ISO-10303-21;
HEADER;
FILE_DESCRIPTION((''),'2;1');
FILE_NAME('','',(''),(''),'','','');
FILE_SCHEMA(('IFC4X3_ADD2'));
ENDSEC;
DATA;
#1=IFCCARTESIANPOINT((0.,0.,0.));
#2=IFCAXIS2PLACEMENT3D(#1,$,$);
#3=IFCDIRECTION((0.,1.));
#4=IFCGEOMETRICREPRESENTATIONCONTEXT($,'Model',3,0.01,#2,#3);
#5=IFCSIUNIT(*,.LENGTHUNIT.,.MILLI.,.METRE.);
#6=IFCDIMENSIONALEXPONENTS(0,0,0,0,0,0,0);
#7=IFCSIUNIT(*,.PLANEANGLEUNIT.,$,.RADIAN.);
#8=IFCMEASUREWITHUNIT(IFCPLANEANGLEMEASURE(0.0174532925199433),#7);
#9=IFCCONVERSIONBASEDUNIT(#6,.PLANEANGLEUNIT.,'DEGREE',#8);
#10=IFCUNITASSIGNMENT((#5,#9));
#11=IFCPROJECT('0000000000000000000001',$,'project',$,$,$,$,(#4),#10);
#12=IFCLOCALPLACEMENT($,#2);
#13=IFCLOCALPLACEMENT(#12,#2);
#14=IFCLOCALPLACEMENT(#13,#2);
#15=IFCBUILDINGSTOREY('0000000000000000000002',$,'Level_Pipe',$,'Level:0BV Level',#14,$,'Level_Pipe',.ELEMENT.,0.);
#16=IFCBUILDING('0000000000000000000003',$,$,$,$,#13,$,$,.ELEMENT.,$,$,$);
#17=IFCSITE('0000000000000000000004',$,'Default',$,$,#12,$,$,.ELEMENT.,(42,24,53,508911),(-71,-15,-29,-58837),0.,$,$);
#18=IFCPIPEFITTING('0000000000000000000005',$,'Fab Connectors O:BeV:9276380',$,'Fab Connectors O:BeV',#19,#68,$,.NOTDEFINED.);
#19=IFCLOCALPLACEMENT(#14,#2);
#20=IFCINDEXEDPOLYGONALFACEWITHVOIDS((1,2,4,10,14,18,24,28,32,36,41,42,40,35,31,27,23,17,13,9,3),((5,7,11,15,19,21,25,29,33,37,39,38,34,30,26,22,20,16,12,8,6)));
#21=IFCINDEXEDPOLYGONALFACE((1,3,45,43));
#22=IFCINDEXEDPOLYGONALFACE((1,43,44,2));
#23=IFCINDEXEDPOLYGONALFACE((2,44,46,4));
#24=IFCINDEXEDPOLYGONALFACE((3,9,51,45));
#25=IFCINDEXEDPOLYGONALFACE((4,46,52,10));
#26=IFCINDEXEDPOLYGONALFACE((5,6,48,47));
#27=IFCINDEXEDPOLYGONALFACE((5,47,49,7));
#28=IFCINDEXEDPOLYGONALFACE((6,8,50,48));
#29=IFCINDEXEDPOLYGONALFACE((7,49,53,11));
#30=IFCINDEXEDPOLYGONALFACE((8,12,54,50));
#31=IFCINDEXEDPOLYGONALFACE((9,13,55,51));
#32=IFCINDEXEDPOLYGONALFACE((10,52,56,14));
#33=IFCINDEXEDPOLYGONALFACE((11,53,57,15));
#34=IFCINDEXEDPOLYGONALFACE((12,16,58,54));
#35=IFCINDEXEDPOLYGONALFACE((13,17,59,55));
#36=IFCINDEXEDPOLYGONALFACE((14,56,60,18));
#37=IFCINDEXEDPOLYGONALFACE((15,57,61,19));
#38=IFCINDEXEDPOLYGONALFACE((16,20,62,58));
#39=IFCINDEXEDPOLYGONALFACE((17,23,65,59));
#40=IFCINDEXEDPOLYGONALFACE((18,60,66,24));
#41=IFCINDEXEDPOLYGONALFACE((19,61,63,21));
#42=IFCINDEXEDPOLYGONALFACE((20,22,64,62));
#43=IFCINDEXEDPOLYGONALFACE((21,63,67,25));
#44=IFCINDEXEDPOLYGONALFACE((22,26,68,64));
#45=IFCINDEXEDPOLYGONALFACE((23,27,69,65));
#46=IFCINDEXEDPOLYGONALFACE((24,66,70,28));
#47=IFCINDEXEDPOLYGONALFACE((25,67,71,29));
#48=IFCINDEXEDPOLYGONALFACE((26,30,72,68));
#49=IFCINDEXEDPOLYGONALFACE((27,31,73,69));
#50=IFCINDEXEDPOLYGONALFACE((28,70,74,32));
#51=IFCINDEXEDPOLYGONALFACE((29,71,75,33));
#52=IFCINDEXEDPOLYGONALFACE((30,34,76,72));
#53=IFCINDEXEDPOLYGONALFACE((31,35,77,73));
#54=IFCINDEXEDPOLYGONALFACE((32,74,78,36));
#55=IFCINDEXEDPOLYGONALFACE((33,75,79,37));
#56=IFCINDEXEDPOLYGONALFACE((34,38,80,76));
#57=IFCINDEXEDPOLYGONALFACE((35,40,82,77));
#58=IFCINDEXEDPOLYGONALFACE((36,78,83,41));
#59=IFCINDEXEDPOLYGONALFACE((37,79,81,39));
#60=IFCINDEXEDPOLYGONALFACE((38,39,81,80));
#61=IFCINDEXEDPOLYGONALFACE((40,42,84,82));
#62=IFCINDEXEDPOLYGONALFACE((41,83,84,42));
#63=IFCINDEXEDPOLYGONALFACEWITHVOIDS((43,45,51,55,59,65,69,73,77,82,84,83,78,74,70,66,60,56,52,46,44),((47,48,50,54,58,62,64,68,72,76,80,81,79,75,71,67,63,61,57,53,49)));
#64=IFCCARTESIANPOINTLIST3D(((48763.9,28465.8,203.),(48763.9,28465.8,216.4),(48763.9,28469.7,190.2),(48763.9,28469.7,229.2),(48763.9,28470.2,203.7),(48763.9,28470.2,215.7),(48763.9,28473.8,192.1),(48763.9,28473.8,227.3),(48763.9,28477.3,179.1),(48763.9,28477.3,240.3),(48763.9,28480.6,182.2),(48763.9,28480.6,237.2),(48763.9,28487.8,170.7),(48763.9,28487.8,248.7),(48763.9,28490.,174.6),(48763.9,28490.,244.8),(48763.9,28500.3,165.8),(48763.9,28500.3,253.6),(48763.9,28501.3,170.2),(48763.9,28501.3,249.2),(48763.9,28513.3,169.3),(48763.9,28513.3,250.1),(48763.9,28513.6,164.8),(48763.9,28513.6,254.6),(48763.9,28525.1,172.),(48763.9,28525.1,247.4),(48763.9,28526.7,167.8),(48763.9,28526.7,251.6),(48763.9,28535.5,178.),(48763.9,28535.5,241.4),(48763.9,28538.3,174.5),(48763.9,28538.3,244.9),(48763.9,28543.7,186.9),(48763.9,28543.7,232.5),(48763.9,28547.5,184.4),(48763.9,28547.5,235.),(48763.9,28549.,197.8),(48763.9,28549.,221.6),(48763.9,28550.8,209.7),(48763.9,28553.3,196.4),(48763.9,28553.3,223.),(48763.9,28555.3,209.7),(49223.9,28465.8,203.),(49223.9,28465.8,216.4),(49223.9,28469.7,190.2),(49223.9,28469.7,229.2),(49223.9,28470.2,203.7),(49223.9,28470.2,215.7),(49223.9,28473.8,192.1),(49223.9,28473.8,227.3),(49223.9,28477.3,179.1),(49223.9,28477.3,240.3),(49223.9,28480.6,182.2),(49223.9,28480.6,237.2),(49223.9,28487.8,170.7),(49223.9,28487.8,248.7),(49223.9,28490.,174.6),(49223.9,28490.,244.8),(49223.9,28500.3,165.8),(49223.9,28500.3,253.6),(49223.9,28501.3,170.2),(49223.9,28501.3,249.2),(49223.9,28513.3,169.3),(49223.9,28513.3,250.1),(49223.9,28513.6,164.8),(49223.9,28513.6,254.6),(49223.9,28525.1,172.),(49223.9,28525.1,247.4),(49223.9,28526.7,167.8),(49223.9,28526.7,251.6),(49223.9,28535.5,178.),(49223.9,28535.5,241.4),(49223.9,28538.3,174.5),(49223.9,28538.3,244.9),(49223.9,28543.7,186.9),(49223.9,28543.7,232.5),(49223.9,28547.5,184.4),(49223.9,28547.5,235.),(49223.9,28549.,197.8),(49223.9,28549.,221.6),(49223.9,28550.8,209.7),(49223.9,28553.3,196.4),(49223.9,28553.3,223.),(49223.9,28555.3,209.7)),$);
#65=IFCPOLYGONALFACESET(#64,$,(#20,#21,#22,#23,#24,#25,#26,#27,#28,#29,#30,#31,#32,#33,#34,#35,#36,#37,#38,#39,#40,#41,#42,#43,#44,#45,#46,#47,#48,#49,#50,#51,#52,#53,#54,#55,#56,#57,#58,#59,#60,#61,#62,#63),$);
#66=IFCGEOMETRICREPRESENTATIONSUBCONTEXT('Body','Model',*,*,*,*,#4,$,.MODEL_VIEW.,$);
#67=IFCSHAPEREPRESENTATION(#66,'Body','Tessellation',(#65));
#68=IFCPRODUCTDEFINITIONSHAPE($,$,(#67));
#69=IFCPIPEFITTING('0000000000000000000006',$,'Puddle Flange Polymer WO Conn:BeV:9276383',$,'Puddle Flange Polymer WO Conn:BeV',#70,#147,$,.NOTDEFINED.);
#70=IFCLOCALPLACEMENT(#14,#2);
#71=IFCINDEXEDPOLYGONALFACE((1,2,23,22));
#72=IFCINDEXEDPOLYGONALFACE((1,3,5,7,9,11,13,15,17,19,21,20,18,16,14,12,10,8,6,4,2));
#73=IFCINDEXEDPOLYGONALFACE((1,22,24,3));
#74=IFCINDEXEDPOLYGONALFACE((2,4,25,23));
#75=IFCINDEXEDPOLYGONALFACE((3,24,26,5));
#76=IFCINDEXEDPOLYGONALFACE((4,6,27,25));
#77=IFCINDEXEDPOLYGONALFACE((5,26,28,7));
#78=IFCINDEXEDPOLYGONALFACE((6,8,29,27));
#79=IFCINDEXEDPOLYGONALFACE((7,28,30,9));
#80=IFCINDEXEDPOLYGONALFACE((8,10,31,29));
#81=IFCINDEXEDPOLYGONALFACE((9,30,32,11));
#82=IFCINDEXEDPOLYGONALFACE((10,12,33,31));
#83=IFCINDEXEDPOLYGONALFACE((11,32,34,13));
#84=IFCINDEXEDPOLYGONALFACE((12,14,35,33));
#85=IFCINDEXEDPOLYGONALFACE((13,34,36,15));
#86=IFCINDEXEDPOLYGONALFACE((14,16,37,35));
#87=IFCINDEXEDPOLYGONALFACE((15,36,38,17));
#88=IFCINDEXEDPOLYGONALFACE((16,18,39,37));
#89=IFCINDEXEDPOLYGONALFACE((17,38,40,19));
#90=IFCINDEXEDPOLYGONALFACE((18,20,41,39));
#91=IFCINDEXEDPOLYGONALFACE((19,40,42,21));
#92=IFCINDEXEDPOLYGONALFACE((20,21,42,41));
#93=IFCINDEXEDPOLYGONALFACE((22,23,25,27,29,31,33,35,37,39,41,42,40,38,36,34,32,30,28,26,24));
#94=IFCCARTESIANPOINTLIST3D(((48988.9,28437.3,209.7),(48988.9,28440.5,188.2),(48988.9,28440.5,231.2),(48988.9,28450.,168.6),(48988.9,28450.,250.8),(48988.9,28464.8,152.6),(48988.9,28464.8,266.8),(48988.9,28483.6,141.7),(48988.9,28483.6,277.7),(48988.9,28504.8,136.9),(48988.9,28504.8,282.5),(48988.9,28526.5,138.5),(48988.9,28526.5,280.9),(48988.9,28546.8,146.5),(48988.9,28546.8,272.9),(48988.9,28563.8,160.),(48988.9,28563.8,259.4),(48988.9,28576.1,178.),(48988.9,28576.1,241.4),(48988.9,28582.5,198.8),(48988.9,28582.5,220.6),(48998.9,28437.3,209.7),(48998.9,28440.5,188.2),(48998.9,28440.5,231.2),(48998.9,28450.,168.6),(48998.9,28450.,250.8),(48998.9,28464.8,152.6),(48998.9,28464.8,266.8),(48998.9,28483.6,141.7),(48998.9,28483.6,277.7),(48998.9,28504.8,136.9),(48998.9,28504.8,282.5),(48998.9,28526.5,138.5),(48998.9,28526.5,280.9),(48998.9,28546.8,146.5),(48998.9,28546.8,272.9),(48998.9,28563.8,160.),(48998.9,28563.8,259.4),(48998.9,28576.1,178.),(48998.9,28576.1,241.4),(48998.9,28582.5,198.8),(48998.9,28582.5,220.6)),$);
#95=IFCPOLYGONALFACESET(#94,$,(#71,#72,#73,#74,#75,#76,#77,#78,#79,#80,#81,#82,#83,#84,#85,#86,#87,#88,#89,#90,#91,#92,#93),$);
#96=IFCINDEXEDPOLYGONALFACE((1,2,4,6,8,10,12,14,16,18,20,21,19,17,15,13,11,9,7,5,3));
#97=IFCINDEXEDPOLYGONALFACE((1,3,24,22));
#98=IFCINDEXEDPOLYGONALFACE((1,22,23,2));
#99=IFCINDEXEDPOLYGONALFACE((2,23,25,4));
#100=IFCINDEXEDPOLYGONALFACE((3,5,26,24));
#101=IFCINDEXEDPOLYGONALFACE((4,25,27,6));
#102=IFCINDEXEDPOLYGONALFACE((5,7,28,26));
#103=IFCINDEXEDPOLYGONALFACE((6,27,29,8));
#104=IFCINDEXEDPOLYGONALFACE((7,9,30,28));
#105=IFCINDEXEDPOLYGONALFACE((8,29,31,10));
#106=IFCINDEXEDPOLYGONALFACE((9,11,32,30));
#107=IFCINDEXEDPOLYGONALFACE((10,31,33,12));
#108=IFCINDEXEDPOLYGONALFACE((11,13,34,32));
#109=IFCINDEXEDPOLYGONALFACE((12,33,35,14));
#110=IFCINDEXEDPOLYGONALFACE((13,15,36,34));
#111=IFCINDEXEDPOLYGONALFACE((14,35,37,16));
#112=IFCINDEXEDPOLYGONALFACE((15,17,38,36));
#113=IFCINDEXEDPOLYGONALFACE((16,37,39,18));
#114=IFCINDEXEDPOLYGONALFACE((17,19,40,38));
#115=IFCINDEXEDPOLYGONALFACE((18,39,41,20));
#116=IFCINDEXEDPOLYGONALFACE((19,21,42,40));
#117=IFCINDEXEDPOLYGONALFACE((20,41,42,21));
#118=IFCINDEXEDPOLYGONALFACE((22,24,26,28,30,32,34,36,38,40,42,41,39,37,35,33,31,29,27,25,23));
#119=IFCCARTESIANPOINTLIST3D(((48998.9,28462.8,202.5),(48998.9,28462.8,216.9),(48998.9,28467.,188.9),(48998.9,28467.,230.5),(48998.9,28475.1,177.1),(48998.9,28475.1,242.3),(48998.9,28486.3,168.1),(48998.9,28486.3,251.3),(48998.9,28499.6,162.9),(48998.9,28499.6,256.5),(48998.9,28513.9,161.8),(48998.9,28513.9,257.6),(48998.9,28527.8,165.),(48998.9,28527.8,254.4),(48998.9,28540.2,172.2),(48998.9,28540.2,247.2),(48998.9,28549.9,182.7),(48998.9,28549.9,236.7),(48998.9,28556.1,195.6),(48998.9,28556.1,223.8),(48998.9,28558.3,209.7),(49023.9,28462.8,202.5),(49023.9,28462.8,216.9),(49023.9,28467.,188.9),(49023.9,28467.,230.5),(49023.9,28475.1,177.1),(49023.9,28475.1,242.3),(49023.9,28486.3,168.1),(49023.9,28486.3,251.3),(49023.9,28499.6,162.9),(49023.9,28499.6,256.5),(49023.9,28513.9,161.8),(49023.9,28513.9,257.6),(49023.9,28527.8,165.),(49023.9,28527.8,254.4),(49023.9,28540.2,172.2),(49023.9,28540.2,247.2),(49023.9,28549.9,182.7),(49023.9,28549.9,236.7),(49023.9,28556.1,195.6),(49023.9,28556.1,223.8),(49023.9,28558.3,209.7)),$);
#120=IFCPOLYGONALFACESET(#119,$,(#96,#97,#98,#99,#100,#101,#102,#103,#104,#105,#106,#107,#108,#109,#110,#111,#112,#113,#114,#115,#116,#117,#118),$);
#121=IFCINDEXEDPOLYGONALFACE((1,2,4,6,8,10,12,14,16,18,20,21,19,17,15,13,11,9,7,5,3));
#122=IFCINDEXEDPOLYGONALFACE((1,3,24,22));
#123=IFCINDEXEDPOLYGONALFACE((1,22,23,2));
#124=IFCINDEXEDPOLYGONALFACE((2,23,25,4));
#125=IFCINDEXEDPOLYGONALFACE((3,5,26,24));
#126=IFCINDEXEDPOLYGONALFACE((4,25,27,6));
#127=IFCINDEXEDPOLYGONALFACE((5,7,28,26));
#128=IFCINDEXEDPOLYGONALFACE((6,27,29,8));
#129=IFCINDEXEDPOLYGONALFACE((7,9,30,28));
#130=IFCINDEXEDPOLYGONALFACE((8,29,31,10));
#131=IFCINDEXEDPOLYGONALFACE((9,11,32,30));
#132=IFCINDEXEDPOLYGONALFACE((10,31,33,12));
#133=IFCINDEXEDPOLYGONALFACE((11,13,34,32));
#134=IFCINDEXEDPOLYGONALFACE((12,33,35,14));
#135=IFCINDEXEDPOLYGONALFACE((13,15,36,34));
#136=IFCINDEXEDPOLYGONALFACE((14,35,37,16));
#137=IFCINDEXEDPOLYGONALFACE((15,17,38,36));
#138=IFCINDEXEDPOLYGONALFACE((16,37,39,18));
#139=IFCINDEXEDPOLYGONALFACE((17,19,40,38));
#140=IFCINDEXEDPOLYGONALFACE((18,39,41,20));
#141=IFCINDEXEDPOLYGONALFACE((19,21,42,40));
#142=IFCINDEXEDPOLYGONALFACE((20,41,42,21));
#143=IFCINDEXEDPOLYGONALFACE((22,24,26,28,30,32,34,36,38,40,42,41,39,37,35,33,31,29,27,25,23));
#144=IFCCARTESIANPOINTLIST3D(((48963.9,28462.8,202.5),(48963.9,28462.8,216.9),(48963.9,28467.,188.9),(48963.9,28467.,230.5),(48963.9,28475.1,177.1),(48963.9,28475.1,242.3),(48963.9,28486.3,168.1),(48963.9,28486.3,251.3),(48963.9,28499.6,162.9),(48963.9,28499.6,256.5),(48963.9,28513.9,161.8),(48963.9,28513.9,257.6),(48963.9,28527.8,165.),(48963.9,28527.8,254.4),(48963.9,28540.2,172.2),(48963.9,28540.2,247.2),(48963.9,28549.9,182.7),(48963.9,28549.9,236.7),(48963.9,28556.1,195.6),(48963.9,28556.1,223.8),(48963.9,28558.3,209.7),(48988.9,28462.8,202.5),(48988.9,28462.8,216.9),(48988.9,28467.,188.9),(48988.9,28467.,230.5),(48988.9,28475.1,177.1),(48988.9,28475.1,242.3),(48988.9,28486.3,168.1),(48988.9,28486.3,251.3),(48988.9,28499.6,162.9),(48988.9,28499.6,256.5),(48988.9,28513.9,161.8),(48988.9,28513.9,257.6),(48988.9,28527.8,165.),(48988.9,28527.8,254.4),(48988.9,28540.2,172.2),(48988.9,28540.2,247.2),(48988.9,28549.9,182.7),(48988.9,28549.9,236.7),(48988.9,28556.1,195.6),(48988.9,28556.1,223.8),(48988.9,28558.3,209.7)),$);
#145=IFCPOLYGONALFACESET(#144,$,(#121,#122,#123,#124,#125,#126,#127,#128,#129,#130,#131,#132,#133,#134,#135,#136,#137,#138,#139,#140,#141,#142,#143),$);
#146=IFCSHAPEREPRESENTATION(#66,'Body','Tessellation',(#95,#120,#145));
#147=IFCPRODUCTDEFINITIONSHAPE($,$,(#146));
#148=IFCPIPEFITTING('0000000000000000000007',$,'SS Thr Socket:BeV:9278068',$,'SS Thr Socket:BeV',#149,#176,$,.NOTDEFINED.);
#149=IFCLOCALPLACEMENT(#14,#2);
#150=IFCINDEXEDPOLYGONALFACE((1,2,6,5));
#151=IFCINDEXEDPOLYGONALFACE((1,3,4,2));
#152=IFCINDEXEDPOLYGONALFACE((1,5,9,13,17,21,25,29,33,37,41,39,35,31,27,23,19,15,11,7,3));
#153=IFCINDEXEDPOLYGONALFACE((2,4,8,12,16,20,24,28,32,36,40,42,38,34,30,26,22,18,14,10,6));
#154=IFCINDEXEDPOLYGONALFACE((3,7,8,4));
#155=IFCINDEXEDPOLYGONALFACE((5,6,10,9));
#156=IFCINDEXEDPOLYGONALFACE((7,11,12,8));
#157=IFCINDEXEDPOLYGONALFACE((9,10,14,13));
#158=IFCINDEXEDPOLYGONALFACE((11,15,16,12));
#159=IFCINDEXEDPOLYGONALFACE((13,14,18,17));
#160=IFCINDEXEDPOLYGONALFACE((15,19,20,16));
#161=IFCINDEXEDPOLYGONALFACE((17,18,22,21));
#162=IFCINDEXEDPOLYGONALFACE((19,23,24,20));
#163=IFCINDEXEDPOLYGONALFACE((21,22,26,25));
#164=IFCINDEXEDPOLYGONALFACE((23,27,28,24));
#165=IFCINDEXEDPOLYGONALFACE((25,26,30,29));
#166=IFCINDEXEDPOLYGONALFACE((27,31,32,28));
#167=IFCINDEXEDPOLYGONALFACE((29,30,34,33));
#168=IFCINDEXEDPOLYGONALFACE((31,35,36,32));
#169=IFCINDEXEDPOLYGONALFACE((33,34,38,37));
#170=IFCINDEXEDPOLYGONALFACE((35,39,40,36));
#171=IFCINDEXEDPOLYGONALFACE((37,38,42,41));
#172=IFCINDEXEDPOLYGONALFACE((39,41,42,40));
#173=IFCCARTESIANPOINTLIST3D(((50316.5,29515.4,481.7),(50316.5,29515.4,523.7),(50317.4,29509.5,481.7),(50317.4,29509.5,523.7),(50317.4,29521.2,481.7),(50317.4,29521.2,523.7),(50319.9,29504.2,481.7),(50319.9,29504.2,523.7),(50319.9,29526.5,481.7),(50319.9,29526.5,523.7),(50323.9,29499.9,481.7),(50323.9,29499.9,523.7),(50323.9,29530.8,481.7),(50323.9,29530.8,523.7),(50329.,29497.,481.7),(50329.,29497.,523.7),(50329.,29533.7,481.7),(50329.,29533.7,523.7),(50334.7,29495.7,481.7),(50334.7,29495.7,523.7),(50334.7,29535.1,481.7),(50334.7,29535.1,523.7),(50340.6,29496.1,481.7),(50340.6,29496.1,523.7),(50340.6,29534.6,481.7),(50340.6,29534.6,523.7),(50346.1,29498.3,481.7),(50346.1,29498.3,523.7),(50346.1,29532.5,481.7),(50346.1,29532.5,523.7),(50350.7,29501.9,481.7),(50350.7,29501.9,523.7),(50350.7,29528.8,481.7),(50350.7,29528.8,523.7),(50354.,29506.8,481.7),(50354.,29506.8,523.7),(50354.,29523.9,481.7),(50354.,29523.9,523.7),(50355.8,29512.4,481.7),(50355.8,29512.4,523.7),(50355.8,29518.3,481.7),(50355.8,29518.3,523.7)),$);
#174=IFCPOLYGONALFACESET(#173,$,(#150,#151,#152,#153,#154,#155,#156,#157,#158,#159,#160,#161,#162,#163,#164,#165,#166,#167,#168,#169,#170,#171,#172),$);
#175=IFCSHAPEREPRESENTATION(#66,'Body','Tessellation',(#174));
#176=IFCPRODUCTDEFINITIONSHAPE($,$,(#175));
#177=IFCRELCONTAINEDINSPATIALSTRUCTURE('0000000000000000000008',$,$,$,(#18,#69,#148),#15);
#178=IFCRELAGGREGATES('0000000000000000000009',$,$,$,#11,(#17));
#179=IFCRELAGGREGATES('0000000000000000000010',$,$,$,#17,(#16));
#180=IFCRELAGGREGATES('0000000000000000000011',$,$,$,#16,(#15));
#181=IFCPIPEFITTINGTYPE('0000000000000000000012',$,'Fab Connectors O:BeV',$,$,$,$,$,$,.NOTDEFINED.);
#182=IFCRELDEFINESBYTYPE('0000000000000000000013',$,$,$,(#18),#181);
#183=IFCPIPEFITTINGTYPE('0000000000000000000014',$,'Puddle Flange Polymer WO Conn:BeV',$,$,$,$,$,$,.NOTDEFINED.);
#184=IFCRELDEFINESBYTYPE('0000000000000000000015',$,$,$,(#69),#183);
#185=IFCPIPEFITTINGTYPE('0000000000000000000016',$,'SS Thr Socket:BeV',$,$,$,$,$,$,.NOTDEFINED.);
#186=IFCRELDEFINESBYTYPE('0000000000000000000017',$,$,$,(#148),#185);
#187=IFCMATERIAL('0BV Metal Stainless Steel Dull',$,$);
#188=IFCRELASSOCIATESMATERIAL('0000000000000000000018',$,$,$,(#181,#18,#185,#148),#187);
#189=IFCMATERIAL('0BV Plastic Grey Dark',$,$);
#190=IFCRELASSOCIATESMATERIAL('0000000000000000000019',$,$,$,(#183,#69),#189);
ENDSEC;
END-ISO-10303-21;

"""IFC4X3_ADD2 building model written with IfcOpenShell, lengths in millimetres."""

from ifc_helpers import new_model, entity, si_unit, converted_unit, direction, frame, frame_2d, origin, place, context, subcontext, project, spatial, circle, hollow_circle, extrude, source, transform, mapped, material, type_object, type_shapes, element, save


model = new_model("IFC4X3_ADD2")

# Units and contexts
model_context = context("Model", 3, precision=0.01, world=origin(), true_north=direction((0.0, 1.0)))
body_context = subcontext(model_context, "Body", "Model", "MODEL_VIEW")
ifc_project = project(units=[si_unit("LENGTHUNIT", "METRE", prefix="MILLI"), converted_unit("PLANEANGLEUNIT", "DEGREE", entity("IfcPlaneAngleMeasure", 0.0174532925199433), si_unit("PLANEANGLEUNIT", "RADIAN"), dimensions=[0, 0, 0, 0, 0, 0, 0])], contexts=[model_context])

# Site, building, storey
site_placement = place(None, origin())
site = spatial("IfcSite", under=ifc_project, at=site_placement, Name="Default", CompositionType="ELEMENT", RefLatitude=(42, 24, 53, 508911), RefLongitude=(-71, -15, -29, -58837), RefElevation=0.0)
building_placement = place(site_placement, origin())
building = spatial("IfcBuilding", under=site, at=building_placement, CompositionType="ELEMENT")
storey_placement = place(building_placement, origin())
storey = spatial("IfcBuildingStorey", under=building, at=storey_placement, Name="Level_Pipe", ObjectType="Level:0BV Level", LongName="Level_Pipe", CompositionType="ELEMENT", Elevation=0.0)

# Shared definitions
ifc_material_1 = material(Name="0BV Metal Stainless Steel Dull")

# Pipe fittings
pipe_fitting_type_1 = type_object("IfcPipeFittingType", Name="Fab Connectors O:BeV", PredefinedType="NOTDEFINED", material=ifc_material_1)
shared_shape_1 = source(origin(), body_context, "Body", "SweptSolid", [
    extrude(hollow_circle(Radius=45.0, WallThickness=4.5, at=frame_2d((0.0, 0.0), x_axis=(1.0, 0.0))), frame((0.0, 46.6, 46.6), z_axis=(1.0, 0.0, 0.0), x_axis=(0.0, 1.0, 0.0)), (0.0, 0.0, 1.0), 460.0),
])
type_shapes(pipe_fitting_type_1, [shared_shape_1])
pipe_fitting_1_placement = place(storey_placement, frame((48763.9, 28463.7, 163.1)))
element("IfcPipeFitting", 1, at=pipe_fitting_1_placement, inside=storey, type_object=pipe_fitting_type_1, material=ifc_material_1, Name="Fab Connectors O:BeV:9276380", ObjectType="Fab Connectors O:BeV", PredefinedType="NOTDEFINED", context=body_context, shape_type="MappedRepresentation", body=[
    mapped(shared_shape_1, transform((0.0, 0.0, 0.0), scale=1.0)),
])
ifc_material_2 = material(Name="0BV Plastic Grey Dark")
pipe_fitting_type_2 = type_object("IfcPipeFittingType", Name="Puddle Flange Polymer WO Conn:BeV", PredefinedType="NOTDEFINED", material=ifc_material_2)
shared_shape_2 = source(origin(), body_context, "Body", "SweptSolid", [
    extrude(circle(Radius=73.0, at=frame_2d((0.0, 0.0), x_axis=(1.0, 0.0))), frame((-5.0, 0.0, 0.0), z_axis=(1.0, 0.0, 0.0), x_axis=(0.0, -1.0, 0.0)), (0.0, 0.0, 1.0), 10.0),
    extrude(circle(Radius=48.0, at=frame_2d((0.0, 0.0), x_axis=(1.0, 0.0))), frame((5.0, 0.0, 0.0), z_axis=(1.0, 0.0, 0.0), x_axis=(0.0, 1.0, 0.0)), (0.0, 0.0, 1.0), 25.0),
    extrude(circle(Radius=48.0, at=frame_2d((0.0, 0.0), x_axis=(1.0, 0.0))), frame((-30.0, 0.0, 0.0), z_axis=(1.0, 0.0, 0.0), x_axis=(0.0, 1.0, 0.0)), (0.0, 0.0, 1.0), 25.0),
])
type_shapes(pipe_fitting_type_2, [shared_shape_2])
pipe_fitting_2_placement = place(storey_placement, frame((48993.9, 28510.3, 209.7)))
element("IfcPipeFitting", 2, at=pipe_fitting_2_placement, inside=storey, type_object=pipe_fitting_type_2, material=ifc_material_2, Name="Puddle Flange Polymer WO Conn:BeV:9276383", ObjectType="Puddle Flange Polymer WO Conn:BeV", PredefinedType="NOTDEFINED", context=body_context, shape_type="MappedRepresentation", body=[
    mapped(shared_shape_2, transform((0.0, 0.0, 0.0), scale=1.0)),
])
pipe_fitting_type_3 = type_object("IfcPipeFittingType", Name="SS Thr Socket:BeV", PredefinedType="NOTDEFINED", material=ifc_material_1)
shared_shape_3 = source(origin(), body_context, "Body", "SweptSolid", [
    extrude(circle(Radius=19.8, at=frame_2d((0.0, 0.0), x_axis=(1.0, 0.0))), frame((-21.0, 0.0, 0.0), z_axis=(1.0, 0.0, 0.0), x_axis=(0.0, 1.0, 0.0)), (0.0, 0.0, 1.0), 42.0),
])
type_shapes(pipe_fitting_type_3, [shared_shape_3])
pipe_fitting_3_placement = place(storey_placement, frame((50336.2, 29515.4, 502.7), z_axis=(0.0, 1.0, 0.0), x_axis=(0.0, 0.0, -1.0)))
element("IfcPipeFitting", 3, at=pipe_fitting_3_placement, inside=storey, type_object=pipe_fitting_type_3, material=ifc_material_1, Name="SS Thr Socket:BeV:9278068", ObjectType="SS Thr Socket:BeV", PredefinedType="NOTDEFINED", context=body_context, shape_type="MappedRepresentation", body=[
    mapped(shared_shape_3, transform((0.0, 0.0, 0.0), scale=1.0)),
])

save(model, "model.ifc")
